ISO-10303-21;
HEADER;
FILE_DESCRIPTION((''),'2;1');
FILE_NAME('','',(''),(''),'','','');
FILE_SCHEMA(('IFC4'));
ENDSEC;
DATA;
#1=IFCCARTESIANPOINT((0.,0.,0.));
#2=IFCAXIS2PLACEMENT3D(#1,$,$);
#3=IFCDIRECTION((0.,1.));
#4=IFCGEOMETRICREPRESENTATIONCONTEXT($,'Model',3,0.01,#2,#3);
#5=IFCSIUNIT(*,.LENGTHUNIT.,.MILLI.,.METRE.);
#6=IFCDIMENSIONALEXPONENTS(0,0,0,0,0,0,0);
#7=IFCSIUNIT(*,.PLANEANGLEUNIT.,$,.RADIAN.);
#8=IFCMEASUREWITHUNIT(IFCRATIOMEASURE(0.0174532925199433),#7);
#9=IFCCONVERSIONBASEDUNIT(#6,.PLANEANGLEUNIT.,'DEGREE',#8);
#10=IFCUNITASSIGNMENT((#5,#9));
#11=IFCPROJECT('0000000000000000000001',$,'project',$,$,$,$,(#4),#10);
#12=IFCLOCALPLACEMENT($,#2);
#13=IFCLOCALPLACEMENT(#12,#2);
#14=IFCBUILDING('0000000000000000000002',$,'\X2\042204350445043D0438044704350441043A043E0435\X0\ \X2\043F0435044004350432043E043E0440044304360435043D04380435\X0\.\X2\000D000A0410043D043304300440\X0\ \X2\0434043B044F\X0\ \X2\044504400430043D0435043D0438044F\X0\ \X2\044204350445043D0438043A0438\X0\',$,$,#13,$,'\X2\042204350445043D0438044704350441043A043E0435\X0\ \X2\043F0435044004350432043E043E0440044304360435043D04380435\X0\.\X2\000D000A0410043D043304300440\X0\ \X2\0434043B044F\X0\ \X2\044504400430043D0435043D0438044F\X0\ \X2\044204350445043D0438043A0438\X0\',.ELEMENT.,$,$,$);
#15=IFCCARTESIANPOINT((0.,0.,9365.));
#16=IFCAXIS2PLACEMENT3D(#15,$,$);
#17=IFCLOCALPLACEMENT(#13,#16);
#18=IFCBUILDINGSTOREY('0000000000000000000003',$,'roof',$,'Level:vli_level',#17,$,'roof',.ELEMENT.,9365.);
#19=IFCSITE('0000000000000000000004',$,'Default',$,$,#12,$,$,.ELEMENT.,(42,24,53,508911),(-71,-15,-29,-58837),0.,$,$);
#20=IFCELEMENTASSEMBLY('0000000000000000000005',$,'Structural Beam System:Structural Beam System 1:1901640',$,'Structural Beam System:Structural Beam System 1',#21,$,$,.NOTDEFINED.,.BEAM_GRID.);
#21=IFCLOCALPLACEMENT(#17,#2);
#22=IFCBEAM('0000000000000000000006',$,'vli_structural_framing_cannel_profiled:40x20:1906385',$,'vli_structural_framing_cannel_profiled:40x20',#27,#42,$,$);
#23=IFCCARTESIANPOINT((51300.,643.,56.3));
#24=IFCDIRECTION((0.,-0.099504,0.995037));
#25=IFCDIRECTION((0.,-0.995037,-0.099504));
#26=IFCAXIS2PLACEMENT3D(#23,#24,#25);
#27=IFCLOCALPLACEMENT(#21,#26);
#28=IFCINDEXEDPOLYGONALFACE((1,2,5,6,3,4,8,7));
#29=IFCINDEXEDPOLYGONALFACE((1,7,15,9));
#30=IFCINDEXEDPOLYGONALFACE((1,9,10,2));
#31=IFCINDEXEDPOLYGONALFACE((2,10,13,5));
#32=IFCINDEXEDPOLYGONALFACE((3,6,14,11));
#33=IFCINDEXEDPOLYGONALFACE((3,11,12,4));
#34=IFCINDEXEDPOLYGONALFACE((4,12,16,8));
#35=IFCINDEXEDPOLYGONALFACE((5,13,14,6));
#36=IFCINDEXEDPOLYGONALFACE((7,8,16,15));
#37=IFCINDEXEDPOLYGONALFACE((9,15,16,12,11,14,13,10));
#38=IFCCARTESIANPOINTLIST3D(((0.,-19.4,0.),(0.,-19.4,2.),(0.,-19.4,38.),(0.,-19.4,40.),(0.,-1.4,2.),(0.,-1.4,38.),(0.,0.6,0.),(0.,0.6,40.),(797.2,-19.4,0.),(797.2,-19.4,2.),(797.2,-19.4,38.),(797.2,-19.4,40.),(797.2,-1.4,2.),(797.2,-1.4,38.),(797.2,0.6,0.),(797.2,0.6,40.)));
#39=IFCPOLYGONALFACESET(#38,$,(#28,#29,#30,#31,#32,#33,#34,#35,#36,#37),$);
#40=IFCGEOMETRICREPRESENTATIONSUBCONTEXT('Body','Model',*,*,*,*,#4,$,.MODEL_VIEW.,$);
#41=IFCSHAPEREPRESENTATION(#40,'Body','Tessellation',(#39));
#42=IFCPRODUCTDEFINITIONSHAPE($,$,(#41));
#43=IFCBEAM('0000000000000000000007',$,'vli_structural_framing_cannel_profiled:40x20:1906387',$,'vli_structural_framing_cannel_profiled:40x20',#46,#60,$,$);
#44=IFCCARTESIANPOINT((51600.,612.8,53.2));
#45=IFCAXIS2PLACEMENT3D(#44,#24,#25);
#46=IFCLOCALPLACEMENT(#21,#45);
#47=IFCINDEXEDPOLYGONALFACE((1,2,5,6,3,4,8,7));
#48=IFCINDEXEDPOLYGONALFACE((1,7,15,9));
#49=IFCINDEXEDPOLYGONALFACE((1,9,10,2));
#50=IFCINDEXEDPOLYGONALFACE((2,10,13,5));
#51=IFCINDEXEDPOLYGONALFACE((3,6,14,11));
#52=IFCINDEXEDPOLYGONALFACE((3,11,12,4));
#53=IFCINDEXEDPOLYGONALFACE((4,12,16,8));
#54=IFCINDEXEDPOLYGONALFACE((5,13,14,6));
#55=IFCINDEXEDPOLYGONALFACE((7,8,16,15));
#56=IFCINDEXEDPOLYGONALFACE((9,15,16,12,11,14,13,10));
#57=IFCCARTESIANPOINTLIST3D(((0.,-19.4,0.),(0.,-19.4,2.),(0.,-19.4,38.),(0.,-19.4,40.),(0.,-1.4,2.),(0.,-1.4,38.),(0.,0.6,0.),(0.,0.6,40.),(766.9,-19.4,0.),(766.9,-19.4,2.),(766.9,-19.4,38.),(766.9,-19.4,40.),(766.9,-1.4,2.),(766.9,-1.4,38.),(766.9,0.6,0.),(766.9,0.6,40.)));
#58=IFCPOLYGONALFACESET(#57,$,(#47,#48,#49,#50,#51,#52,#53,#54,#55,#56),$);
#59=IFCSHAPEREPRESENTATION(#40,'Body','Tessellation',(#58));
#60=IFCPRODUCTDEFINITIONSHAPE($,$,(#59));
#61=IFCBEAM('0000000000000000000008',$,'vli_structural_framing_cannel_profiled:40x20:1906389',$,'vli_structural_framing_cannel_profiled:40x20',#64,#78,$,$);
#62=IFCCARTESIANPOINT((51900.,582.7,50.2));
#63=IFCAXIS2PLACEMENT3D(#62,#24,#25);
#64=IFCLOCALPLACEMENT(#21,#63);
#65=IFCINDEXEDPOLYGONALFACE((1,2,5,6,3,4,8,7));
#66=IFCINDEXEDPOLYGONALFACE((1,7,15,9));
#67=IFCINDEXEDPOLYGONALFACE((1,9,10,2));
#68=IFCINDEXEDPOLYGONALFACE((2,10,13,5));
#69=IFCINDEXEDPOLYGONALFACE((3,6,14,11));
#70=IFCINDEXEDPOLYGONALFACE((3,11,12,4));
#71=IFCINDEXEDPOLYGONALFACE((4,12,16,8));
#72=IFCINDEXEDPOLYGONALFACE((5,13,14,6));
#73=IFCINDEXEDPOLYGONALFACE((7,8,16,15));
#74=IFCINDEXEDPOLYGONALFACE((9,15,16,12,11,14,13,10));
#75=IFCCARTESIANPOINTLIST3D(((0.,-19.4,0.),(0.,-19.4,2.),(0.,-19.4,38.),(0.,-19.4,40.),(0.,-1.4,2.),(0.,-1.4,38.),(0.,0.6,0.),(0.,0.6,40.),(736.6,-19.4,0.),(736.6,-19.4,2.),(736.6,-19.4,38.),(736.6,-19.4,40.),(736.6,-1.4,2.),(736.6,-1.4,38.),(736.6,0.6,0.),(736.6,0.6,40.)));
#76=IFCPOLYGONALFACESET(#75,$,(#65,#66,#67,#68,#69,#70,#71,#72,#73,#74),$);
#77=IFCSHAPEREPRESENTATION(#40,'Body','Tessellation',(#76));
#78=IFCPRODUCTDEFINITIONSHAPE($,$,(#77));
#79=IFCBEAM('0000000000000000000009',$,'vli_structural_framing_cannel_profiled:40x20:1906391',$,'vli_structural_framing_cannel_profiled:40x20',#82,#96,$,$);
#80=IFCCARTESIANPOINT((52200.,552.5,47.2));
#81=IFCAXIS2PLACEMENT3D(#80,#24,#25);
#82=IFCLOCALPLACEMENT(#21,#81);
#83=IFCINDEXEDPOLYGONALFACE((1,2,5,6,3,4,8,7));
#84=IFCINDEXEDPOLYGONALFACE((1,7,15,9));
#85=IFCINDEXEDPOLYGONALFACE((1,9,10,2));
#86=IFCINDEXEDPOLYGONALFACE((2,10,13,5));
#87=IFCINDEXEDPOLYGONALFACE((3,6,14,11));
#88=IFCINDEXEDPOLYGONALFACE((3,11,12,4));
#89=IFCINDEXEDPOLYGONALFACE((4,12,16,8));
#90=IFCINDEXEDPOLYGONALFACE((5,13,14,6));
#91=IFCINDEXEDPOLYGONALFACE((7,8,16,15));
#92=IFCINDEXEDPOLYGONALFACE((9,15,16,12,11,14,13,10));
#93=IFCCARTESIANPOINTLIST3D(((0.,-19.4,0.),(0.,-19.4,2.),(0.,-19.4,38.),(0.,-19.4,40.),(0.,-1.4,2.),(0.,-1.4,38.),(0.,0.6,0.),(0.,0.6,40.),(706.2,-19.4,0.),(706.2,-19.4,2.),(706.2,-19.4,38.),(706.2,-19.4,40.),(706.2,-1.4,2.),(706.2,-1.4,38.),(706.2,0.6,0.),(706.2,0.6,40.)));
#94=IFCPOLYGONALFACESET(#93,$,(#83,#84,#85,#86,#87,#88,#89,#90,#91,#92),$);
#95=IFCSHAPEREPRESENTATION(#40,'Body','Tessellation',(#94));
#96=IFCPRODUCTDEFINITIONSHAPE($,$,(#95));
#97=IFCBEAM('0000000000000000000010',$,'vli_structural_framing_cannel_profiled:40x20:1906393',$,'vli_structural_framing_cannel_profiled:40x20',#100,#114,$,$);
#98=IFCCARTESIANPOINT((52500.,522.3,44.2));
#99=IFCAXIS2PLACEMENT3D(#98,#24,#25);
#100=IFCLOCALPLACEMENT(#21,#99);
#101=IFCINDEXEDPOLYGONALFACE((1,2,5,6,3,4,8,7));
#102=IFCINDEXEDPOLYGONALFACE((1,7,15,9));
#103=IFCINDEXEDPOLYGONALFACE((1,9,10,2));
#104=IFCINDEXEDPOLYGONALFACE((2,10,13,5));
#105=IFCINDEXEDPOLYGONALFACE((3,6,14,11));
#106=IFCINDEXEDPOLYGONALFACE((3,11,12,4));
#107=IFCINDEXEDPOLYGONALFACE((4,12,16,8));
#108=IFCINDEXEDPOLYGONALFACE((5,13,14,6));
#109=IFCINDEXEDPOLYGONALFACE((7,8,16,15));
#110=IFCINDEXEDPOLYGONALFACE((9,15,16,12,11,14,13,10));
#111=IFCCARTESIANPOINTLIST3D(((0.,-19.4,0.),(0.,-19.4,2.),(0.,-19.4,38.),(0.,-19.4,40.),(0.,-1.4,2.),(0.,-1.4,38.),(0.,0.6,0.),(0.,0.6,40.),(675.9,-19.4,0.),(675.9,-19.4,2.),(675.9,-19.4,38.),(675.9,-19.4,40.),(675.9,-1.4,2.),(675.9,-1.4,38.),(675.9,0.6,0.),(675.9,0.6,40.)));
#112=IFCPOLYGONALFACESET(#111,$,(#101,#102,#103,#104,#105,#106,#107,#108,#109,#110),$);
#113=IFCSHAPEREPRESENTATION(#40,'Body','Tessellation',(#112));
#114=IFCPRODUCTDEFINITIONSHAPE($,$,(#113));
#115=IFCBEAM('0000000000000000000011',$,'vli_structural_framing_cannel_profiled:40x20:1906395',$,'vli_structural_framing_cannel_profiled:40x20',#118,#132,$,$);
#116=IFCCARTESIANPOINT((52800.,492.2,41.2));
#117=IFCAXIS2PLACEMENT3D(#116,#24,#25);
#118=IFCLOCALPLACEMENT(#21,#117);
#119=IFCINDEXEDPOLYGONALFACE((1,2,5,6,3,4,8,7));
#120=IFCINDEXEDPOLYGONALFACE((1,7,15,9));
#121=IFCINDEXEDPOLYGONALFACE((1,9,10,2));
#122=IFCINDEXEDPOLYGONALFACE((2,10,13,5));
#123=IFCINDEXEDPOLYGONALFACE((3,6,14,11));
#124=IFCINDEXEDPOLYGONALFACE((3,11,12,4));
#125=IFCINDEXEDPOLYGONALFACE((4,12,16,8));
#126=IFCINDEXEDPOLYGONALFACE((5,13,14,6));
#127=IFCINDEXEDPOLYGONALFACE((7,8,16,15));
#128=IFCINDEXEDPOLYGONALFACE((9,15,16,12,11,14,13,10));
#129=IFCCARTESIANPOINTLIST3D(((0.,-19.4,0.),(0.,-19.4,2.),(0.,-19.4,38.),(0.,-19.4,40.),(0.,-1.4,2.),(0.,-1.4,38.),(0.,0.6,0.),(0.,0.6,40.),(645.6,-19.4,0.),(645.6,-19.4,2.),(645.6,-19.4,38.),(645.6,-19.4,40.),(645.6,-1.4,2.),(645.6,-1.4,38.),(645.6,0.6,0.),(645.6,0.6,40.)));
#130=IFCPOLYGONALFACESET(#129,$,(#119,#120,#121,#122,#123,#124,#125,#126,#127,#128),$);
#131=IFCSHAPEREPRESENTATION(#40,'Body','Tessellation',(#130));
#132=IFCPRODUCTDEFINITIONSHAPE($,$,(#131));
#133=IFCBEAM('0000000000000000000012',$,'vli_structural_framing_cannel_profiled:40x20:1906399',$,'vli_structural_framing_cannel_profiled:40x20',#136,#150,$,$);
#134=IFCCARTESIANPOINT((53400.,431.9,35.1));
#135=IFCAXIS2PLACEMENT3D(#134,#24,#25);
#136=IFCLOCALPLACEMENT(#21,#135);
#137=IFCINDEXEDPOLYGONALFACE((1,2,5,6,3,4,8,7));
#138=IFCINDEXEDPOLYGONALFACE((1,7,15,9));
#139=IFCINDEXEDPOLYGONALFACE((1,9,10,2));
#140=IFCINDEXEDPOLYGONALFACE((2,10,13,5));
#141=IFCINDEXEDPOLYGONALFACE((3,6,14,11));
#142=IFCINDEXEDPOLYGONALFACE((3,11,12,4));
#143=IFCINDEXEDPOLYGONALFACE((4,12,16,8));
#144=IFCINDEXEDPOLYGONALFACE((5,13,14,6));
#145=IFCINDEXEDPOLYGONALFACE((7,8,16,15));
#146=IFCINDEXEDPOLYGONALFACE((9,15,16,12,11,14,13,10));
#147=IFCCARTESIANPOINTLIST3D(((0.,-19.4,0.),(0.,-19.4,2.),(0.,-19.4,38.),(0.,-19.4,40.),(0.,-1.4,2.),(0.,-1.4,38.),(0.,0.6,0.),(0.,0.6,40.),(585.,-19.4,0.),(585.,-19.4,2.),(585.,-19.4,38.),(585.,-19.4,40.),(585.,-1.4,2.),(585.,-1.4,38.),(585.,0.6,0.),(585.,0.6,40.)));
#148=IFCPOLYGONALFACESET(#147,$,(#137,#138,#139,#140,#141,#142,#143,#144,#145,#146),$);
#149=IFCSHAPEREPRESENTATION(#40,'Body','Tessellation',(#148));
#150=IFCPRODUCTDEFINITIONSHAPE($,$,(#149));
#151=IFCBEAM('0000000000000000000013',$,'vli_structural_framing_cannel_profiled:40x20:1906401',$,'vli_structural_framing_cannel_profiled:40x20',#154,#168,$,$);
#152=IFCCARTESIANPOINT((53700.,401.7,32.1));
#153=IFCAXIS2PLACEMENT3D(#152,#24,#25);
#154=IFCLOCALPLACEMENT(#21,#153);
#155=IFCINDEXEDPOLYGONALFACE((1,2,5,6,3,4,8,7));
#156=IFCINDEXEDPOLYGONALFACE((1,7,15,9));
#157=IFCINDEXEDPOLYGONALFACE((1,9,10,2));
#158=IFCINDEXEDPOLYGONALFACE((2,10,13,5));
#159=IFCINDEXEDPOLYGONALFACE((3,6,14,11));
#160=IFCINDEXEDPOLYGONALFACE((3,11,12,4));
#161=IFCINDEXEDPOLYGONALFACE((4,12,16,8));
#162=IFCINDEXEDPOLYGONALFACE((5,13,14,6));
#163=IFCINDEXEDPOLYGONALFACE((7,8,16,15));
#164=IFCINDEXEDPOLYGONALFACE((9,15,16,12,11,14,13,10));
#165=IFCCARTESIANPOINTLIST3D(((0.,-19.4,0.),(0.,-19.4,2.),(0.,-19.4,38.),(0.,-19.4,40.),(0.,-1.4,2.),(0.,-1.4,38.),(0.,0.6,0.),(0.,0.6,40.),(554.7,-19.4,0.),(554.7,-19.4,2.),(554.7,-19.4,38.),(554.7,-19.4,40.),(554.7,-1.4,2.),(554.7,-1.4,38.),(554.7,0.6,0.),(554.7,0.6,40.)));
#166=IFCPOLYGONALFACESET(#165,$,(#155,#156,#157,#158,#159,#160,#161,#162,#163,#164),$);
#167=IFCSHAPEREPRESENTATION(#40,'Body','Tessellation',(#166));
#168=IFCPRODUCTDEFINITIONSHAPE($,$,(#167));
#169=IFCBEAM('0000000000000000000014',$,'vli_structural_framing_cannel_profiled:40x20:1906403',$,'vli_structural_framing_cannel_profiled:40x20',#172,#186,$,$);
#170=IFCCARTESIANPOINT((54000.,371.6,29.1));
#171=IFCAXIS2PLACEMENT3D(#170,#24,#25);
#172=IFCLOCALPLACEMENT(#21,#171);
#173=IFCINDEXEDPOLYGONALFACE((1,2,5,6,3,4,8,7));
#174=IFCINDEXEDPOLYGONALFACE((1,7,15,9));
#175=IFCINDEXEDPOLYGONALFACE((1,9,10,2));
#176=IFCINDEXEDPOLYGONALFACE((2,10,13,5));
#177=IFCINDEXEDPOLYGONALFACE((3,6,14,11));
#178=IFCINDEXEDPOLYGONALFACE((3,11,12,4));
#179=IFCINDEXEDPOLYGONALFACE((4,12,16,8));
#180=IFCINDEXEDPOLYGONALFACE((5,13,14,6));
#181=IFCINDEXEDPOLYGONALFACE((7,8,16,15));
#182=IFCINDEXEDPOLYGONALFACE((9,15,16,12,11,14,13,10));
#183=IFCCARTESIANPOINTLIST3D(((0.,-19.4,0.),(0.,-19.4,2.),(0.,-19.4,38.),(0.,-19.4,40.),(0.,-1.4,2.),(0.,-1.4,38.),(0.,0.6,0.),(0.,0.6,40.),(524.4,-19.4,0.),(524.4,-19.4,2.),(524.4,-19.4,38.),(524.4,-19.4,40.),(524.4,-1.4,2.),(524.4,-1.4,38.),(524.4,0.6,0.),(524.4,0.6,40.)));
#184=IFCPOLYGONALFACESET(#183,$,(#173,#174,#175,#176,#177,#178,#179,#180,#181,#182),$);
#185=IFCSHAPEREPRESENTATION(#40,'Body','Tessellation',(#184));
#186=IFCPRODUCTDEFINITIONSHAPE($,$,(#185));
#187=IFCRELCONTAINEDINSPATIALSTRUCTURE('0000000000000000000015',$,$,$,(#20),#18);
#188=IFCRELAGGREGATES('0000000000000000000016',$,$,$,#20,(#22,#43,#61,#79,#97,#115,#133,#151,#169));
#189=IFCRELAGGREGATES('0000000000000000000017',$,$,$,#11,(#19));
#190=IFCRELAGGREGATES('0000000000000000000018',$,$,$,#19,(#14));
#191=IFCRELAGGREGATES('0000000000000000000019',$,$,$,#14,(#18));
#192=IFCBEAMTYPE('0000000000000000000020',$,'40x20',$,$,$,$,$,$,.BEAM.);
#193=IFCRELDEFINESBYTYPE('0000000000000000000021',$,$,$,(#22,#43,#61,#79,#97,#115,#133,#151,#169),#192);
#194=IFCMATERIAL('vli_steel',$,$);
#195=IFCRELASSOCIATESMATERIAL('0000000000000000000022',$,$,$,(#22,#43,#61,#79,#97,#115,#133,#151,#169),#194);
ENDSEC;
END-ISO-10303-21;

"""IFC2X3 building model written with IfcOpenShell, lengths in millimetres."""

from ifc_helpers import new_model, entity, si_unit, converted_unit, direction, frame, origin, place, context, subcontext, project, spatial, polyline, outline, extrude, material, type_object, element, aggregate, save


model = new_model("IFC2X3")

# Units and contexts
model_context = context("Model", 3, precision=0.01, world=origin(), true_north=direction((0.0, 1.0)))
body_context = subcontext(model_context, "Body", "Model", "MODEL_VIEW")
ifc_project = project(units=[si_unit("LENGTHUNIT", "METRE", prefix="MILLI"), converted_unit("PLANEANGLEUNIT", "DEGREE", entity("IfcRatioMeasure", 0.0174532925199433), si_unit("PLANEANGLEUNIT", "RADIAN"), dimensions=[0, 0, 0, 0, 0, 0, 0])], contexts=[model_context])

# Site, building, storey
site_placement = place(None, origin())
site = spatial("IfcSite", under=ifc_project, at=site_placement, Name="Default", CompositionType="ELEMENT", RefLatitude=(42, 24, 53, 508911), RefLongitude=(-71, -15, -29, -58837), RefElevation=0.0)
building_placement = place(site_placement, origin())
building = spatial("IfcBuilding", under=site, at=building_placement, Name="Техническое перевооружение.\r\nАнгар для хранения техники", LongName="Техническое перевооружение.\r\nАнгар для хранения техники", CompositionType="ELEMENT")
storey_placement = place(building_placement, frame((0.0, 0.0, 9365.0)))
storey = spatial("IfcBuildingStorey", under=building, at=storey_placement, Name="roof", ObjectType="Level:vli_level", LongName="roof", CompositionType="ELEMENT", Elevation=9365.0)

# Element assembly, beams
assembly_1_placement = place(storey_placement, origin())
assembly_1 = element("IfcElementAssembly", 1, at=assembly_1_placement, inside=storey, Name="Structural Beam System:Structural Beam System 1:1901640", ObjectType="Structural Beam System:Structural Beam System 1", AssemblyPlace="NOTDEFINED", PredefinedType="BEAM_GRID")
ifc_material = material(Name="vli_steel")
beam_type = type_object("IfcBeamType", Name="40x20", PredefinedType="BEAM")
beam_1_placement = place(assembly_1_placement, frame((51300.0, 643.0, 56.3), z_axis=(0.0, -0.099504, 0.995037), x_axis=(0.0, -0.995037, -0.099504)))
beam_1 = element("IfcBeam", 2, at=beam_1_placement, type_object=beam_type, material=ifc_material, Name="vli_structural_framing_cannel_profiled:40x20:1906385", ObjectType="vli_structural_framing_cannel_profiled:40x20", context=body_context, shape_type="SweptSolid", body=[
    extrude(outline(polyline([(-20.0, -9.5), (-18.0, -9.5), (-18.0, 8.5), (18.0, 8.5), (18.0, -9.5), (20.0, -9.5), (20.0, 10.5), (-20.0, 10.5), (-20.0, -9.5)])), frame((0.0, -9.9, 20.0), z_axis=(1.0, 0.0, 0.0), x_axis=(0.0, 0.0, -1.0)), (0.0, 0.0, 1.0), 797.2),
])
beam_2_placement = place(assembly_1_placement, frame((51600.0, 612.8, 53.2), z_axis=(0.0, -0.099504, 0.995037), x_axis=(0.0, -0.995037, -0.099504)))
beam_2 = element("IfcBeam", 3, at=beam_2_placement, type_object=beam_type, material=ifc_material, Name="vli_structural_framing_cannel_profiled:40x20:1906387", ObjectType="vli_structural_framing_cannel_profiled:40x20", context=body_context, shape_type="SweptSolid", body=[
    extrude(outline(polyline([(-20.0, -9.5), (-18.0, -9.5), (-18.0, 8.5), (18.0, 8.5), (18.0, -9.5), (20.0, -9.5), (20.0, 10.5), (-20.0, 10.5), (-20.0, -9.5)])), frame((0.0, -9.9, 20.0), z_axis=(1.0, 0.0, 0.0), x_axis=(0.0, 0.0, -1.0)), (0.0, 0.0, 1.0), 766.9),
])
beam_3_placement = place(assembly_1_placement, frame((51900.0, 582.7, 50.2), z_axis=(0.0, -0.099504, 0.995037), x_axis=(0.0, -0.995037, -0.099504)))
beam_3 = element("IfcBeam", 4, at=beam_3_placement, type_object=beam_type, material=ifc_material, Name="vli_structural_framing_cannel_profiled:40x20:1906389", ObjectType="vli_structural_framing_cannel_profiled:40x20", context=body_context, shape_type="SweptSolid", body=[
    extrude(outline(polyline([(-20.0, -9.5), (-18.0, -9.5), (-18.0, 8.5), (18.0, 8.5), (18.0, -9.5), (20.0, -9.5), (20.0, 10.5), (-20.0, 10.5), (-20.0, -9.5)])), frame((0.0, -9.9, 20.0), z_axis=(1.0, 0.0, 0.0), x_axis=(0.0, 0.0, -1.0)), (0.0, 0.0, 1.0), 736.6),
])
beam_4_placement = place(assembly_1_placement, frame((52200.0, 552.5, 47.2), z_axis=(0.0, -0.099504, 0.995037), x_axis=(0.0, -0.995037, -0.099504)))
beam_4 = element("IfcBeam", 5, at=beam_4_placement, type_object=beam_type, material=ifc_material, Name="vli_structural_framing_cannel_profiled:40x20:1906391", ObjectType="vli_structural_framing_cannel_profiled:40x20", context=body_context, shape_type="SweptSolid", body=[
    extrude(outline(polyline([(-20.0, -9.5), (-18.0, -9.5), (-18.0, 8.5), (18.0, 8.5), (18.0, -9.5), (20.0, -9.5), (20.0, 10.5), (-20.0, 10.5), (-20.0, -9.5)])), frame((0.0, -9.9, 20.0), z_axis=(1.0, 0.0, 0.0), x_axis=(0.0, 0.0, -1.0)), (0.0, 0.0, 1.0), 706.2),
])
beam_5_placement = place(assembly_1_placement, frame((52500.0, 522.3, 44.2), z_axis=(0.0, -0.099504, 0.995037), x_axis=(0.0, -0.995037, -0.099504)))
beam_5 = element("IfcBeam", 6, at=beam_5_placement, type_object=beam_type, material=ifc_material, Name="vli_structural_framing_cannel_profiled:40x20:1906393", ObjectType="vli_structural_framing_cannel_profiled:40x20", context=body_context, shape_type="SweptSolid", body=[
    extrude(outline(polyline([(-20.0, -9.5), (-18.0, -9.5), (-18.0, 8.5), (18.0, 8.5), (18.0, -9.5), (20.0, -9.5), (20.0, 10.5), (-20.0, 10.5), (-20.0, -9.5)])), frame((0.0, -9.9, 20.0), z_axis=(1.0, 0.0, 0.0), x_axis=(0.0, 0.0, -1.0)), (0.0, 0.0, 1.0), 675.9),
])
beam_6_placement = place(assembly_1_placement, frame((52800.0, 492.2, 41.2), z_axis=(0.0, -0.099504, 0.995037), x_axis=(0.0, -0.995037, -0.099504)))
beam_6 = element("IfcBeam", 7, at=beam_6_placement, type_object=beam_type, material=ifc_material, Name="vli_structural_framing_cannel_profiled:40x20:1906395", ObjectType="vli_structural_framing_cannel_profiled:40x20", context=body_context, shape_type="SweptSolid", body=[
    extrude(outline(polyline([(-20.0, -9.5), (-18.0, -9.5), (-18.0, 8.5), (18.0, 8.5), (18.0, -9.5), (20.0, -9.5), (20.0, 10.5), (-20.0, 10.5), (-20.0, -9.5)])), frame((0.0, -9.9, 20.0), z_axis=(1.0, 0.0, 0.0), x_axis=(0.0, 0.0, -1.0)), (0.0, 0.0, 1.0), 645.6),
])
beam_7_placement = place(assembly_1_placement, frame((53400.0, 431.9, 35.1), z_axis=(0.0, -0.099504, 0.995037), x_axis=(0.0, -0.995037, -0.099504)))
beam_7 = element("IfcBeam", 8, at=beam_7_placement, type_object=beam_type, material=ifc_material, Name="vli_structural_framing_cannel_profiled:40x20:1906399", ObjectType="vli_structural_framing_cannel_profiled:40x20", context=body_context, shape_type="SweptSolid", body=[
    extrude(outline(polyline([(-20.0, -9.5), (-18.0, -9.5), (-18.0, 8.5), (18.0, 8.5), (18.0, -9.5), (20.0, -9.5), (20.0, 10.5), (-20.0, 10.5), (-20.0, -9.5)])), frame((0.0, -9.9, 20.0), z_axis=(1.0, 0.0, 0.0), x_axis=(0.0, 0.0, -1.0)), (0.0, 0.0, 1.0), 585.0),
])
beam_8_placement = place(assembly_1_placement, frame((53700.0, 401.7, 32.1), z_axis=(0.0, -0.099504, 0.995037), x_axis=(0.0, -0.995037, -0.099504)))
beam_8 = element("IfcBeam", 9, at=beam_8_placement, type_object=beam_type, material=ifc_material, Name="vli_structural_framing_cannel_profiled:40x20:1906401", ObjectType="vli_structural_framing_cannel_profiled:40x20", context=body_context, shape_type="SweptSolid", body=[
    extrude(outline(polyline([(-20.0, -9.5), (-18.0, -9.5), (-18.0, 8.5), (18.0, 8.5), (18.0, -9.5), (20.0, -9.5), (20.0, 10.5), (-20.0, 10.5), (-20.0, -9.5)])), frame((0.0, -9.9, 20.0), z_axis=(1.0, 0.0, 0.0), x_axis=(0.0, 0.0, -1.0)), (0.0, 0.0, 1.0), 554.7),
])
beam_9_placement = place(assembly_1_placement, frame((54000.0, 371.6, 29.1), z_axis=(0.0, -0.099504, 0.995037), x_axis=(0.0, -0.995037, -0.099504)))
beam_9 = element("IfcBeam", 10, at=beam_9_placement, type_object=beam_type, material=ifc_material, Name="vli_structural_framing_cannel_profiled:40x20:1906403", ObjectType="vli_structural_framing_cannel_profiled:40x20", context=body_context, shape_type="SweptSolid", body=[
    extrude(outline(polyline([(-20.0, -9.5), (-18.0, -9.5), (-18.0, 8.5), (18.0, 8.5), (18.0, -9.5), (20.0, -9.5), (20.0, 10.5), (-20.0, 10.5), (-20.0, -9.5)])), frame((0.0, -9.9, 20.0), z_axis=(1.0, 0.0, 0.0), x_axis=(0.0, 0.0, -1.0)), (0.0, 0.0, 1.0), 524.4),
])
aggregate(assembly_1, [beam_1, beam_2, beam_3, beam_4, beam_5, beam_6, beam_7, beam_8, beam_9])

save(model, "model.ifc")
